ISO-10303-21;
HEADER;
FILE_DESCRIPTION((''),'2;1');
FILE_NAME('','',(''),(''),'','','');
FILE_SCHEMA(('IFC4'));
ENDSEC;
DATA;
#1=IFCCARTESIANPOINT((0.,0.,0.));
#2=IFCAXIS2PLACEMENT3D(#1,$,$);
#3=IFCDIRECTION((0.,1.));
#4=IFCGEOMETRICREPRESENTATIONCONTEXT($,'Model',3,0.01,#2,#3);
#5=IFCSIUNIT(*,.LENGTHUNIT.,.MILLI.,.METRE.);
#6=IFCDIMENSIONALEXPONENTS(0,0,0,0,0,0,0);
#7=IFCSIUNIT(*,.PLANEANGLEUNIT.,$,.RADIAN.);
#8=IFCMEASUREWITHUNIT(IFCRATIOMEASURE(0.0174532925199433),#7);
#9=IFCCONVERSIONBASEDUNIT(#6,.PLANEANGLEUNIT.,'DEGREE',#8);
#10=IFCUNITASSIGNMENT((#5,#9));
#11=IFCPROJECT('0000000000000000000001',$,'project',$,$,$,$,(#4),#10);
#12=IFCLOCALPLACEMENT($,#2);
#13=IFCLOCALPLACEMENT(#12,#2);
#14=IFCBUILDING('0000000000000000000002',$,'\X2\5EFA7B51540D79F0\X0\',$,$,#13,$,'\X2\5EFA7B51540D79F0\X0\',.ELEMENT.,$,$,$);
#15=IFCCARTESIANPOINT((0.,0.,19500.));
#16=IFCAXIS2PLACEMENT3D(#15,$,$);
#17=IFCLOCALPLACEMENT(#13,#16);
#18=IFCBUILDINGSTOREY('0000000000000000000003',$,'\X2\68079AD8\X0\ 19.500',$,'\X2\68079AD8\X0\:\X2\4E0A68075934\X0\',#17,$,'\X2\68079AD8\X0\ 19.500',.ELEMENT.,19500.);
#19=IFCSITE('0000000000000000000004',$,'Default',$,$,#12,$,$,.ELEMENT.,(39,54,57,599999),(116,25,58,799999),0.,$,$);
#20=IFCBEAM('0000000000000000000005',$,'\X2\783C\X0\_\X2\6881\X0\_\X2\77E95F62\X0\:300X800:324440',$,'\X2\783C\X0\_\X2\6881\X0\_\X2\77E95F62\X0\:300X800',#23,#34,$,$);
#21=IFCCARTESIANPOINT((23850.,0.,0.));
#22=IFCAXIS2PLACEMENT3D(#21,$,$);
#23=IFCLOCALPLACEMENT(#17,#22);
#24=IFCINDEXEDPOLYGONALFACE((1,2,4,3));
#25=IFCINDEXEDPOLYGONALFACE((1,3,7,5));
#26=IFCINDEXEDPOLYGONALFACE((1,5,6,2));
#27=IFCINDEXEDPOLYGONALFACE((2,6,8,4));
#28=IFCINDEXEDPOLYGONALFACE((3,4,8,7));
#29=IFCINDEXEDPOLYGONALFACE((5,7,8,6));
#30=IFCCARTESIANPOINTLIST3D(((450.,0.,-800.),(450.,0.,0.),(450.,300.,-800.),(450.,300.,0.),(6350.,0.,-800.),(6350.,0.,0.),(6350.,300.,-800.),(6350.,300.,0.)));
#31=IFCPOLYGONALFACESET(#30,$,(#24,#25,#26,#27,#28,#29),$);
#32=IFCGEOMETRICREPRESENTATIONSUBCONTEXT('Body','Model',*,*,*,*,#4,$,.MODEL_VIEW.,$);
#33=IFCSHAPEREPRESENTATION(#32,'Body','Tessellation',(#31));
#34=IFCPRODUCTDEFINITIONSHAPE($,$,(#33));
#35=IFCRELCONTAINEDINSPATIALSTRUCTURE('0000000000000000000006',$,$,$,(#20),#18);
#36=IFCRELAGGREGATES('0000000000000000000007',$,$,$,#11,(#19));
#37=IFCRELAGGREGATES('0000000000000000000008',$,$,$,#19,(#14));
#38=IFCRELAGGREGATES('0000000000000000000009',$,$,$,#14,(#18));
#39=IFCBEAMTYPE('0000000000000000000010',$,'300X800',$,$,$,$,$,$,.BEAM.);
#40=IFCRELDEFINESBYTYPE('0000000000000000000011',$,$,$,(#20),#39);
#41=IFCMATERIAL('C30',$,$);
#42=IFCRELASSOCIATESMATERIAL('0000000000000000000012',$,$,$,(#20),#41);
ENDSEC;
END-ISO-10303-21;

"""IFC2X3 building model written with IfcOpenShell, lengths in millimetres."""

from ifc_helpers import new_model, entity, si_unit, converted_unit, direction, frame, origin, origin_2d_with_axis, place, context, subcontext, project, spatial, rectangle, extrude, material, type_object, element, save


model = new_model("IFC2X3")

# Units and contexts
model_context = context("Model", 3, precision=0.01, world=origin(), true_north=direction((0.0, 1.0)))
body_context = subcontext(model_context, "Body", "Model", "MODEL_VIEW")
ifc_project = project(units=[si_unit("LENGTHUNIT", "METRE", prefix="MILLI"), converted_unit("PLANEANGLEUNIT", "DEGREE", entity("IfcRatioMeasure", 0.0174532925199433), si_unit("PLANEANGLEUNIT", "RADIAN"), dimensions=[0, 0, 0, 0, 0, 0, 0])], contexts=[model_context])

# Site, building, storey
site_placement = place(None, origin())
site = spatial("IfcSite", under=ifc_project, at=site_placement, Name="Default", CompositionType="ELEMENT", RefLatitude=(39, 54, 57, 599999), RefLongitude=(116, 25, 58, 799999), RefElevation=0.0)
building_placement = place(site_placement, origin())
building = spatial("IfcBuilding", under=site, at=building_placement, Name="建筑名称", LongName="建筑名称", CompositionType="ELEMENT")
storey_placement = place(building_placement, frame((0.0, 0.0, 19500.0)))
storey = spatial("IfcBuildingStorey", under=building, at=storey_placement, Name="标高 19.500", ObjectType="标高:上标头", LongName="标高 19.500", CompositionType="ELEMENT", Elevation=19500.0)

# Beam
ifc_material_1 = material(Name="C30")
beam_type_1 = type_object("IfcBeamType", Name="300X800", PredefinedType="BEAM")
beam_1_placement = place(storey_placement, frame((23850.0, 0.0, 0.0)))
element("IfcBeam", 1, at=beam_1_placement, inside=storey, type_object=beam_type_1, material=ifc_material_1, Name="砼_梁_矩形:300X800:324440", ObjectType="砼_梁_矩形:300X800", context=body_context, shape_type="SweptSolid", body=[
    extrude(rectangle(XDim=800.0, YDim=300.0, at=origin_2d_with_axis()), frame((450.0, 150.0, -400.0), z_axis=(1.0, 0.0, 0.0), x_axis=(0.0, 0.0, -1.0)), (0.0, 0.0, 1.0), 5900.0),
])

save(model, "model.ifc")
